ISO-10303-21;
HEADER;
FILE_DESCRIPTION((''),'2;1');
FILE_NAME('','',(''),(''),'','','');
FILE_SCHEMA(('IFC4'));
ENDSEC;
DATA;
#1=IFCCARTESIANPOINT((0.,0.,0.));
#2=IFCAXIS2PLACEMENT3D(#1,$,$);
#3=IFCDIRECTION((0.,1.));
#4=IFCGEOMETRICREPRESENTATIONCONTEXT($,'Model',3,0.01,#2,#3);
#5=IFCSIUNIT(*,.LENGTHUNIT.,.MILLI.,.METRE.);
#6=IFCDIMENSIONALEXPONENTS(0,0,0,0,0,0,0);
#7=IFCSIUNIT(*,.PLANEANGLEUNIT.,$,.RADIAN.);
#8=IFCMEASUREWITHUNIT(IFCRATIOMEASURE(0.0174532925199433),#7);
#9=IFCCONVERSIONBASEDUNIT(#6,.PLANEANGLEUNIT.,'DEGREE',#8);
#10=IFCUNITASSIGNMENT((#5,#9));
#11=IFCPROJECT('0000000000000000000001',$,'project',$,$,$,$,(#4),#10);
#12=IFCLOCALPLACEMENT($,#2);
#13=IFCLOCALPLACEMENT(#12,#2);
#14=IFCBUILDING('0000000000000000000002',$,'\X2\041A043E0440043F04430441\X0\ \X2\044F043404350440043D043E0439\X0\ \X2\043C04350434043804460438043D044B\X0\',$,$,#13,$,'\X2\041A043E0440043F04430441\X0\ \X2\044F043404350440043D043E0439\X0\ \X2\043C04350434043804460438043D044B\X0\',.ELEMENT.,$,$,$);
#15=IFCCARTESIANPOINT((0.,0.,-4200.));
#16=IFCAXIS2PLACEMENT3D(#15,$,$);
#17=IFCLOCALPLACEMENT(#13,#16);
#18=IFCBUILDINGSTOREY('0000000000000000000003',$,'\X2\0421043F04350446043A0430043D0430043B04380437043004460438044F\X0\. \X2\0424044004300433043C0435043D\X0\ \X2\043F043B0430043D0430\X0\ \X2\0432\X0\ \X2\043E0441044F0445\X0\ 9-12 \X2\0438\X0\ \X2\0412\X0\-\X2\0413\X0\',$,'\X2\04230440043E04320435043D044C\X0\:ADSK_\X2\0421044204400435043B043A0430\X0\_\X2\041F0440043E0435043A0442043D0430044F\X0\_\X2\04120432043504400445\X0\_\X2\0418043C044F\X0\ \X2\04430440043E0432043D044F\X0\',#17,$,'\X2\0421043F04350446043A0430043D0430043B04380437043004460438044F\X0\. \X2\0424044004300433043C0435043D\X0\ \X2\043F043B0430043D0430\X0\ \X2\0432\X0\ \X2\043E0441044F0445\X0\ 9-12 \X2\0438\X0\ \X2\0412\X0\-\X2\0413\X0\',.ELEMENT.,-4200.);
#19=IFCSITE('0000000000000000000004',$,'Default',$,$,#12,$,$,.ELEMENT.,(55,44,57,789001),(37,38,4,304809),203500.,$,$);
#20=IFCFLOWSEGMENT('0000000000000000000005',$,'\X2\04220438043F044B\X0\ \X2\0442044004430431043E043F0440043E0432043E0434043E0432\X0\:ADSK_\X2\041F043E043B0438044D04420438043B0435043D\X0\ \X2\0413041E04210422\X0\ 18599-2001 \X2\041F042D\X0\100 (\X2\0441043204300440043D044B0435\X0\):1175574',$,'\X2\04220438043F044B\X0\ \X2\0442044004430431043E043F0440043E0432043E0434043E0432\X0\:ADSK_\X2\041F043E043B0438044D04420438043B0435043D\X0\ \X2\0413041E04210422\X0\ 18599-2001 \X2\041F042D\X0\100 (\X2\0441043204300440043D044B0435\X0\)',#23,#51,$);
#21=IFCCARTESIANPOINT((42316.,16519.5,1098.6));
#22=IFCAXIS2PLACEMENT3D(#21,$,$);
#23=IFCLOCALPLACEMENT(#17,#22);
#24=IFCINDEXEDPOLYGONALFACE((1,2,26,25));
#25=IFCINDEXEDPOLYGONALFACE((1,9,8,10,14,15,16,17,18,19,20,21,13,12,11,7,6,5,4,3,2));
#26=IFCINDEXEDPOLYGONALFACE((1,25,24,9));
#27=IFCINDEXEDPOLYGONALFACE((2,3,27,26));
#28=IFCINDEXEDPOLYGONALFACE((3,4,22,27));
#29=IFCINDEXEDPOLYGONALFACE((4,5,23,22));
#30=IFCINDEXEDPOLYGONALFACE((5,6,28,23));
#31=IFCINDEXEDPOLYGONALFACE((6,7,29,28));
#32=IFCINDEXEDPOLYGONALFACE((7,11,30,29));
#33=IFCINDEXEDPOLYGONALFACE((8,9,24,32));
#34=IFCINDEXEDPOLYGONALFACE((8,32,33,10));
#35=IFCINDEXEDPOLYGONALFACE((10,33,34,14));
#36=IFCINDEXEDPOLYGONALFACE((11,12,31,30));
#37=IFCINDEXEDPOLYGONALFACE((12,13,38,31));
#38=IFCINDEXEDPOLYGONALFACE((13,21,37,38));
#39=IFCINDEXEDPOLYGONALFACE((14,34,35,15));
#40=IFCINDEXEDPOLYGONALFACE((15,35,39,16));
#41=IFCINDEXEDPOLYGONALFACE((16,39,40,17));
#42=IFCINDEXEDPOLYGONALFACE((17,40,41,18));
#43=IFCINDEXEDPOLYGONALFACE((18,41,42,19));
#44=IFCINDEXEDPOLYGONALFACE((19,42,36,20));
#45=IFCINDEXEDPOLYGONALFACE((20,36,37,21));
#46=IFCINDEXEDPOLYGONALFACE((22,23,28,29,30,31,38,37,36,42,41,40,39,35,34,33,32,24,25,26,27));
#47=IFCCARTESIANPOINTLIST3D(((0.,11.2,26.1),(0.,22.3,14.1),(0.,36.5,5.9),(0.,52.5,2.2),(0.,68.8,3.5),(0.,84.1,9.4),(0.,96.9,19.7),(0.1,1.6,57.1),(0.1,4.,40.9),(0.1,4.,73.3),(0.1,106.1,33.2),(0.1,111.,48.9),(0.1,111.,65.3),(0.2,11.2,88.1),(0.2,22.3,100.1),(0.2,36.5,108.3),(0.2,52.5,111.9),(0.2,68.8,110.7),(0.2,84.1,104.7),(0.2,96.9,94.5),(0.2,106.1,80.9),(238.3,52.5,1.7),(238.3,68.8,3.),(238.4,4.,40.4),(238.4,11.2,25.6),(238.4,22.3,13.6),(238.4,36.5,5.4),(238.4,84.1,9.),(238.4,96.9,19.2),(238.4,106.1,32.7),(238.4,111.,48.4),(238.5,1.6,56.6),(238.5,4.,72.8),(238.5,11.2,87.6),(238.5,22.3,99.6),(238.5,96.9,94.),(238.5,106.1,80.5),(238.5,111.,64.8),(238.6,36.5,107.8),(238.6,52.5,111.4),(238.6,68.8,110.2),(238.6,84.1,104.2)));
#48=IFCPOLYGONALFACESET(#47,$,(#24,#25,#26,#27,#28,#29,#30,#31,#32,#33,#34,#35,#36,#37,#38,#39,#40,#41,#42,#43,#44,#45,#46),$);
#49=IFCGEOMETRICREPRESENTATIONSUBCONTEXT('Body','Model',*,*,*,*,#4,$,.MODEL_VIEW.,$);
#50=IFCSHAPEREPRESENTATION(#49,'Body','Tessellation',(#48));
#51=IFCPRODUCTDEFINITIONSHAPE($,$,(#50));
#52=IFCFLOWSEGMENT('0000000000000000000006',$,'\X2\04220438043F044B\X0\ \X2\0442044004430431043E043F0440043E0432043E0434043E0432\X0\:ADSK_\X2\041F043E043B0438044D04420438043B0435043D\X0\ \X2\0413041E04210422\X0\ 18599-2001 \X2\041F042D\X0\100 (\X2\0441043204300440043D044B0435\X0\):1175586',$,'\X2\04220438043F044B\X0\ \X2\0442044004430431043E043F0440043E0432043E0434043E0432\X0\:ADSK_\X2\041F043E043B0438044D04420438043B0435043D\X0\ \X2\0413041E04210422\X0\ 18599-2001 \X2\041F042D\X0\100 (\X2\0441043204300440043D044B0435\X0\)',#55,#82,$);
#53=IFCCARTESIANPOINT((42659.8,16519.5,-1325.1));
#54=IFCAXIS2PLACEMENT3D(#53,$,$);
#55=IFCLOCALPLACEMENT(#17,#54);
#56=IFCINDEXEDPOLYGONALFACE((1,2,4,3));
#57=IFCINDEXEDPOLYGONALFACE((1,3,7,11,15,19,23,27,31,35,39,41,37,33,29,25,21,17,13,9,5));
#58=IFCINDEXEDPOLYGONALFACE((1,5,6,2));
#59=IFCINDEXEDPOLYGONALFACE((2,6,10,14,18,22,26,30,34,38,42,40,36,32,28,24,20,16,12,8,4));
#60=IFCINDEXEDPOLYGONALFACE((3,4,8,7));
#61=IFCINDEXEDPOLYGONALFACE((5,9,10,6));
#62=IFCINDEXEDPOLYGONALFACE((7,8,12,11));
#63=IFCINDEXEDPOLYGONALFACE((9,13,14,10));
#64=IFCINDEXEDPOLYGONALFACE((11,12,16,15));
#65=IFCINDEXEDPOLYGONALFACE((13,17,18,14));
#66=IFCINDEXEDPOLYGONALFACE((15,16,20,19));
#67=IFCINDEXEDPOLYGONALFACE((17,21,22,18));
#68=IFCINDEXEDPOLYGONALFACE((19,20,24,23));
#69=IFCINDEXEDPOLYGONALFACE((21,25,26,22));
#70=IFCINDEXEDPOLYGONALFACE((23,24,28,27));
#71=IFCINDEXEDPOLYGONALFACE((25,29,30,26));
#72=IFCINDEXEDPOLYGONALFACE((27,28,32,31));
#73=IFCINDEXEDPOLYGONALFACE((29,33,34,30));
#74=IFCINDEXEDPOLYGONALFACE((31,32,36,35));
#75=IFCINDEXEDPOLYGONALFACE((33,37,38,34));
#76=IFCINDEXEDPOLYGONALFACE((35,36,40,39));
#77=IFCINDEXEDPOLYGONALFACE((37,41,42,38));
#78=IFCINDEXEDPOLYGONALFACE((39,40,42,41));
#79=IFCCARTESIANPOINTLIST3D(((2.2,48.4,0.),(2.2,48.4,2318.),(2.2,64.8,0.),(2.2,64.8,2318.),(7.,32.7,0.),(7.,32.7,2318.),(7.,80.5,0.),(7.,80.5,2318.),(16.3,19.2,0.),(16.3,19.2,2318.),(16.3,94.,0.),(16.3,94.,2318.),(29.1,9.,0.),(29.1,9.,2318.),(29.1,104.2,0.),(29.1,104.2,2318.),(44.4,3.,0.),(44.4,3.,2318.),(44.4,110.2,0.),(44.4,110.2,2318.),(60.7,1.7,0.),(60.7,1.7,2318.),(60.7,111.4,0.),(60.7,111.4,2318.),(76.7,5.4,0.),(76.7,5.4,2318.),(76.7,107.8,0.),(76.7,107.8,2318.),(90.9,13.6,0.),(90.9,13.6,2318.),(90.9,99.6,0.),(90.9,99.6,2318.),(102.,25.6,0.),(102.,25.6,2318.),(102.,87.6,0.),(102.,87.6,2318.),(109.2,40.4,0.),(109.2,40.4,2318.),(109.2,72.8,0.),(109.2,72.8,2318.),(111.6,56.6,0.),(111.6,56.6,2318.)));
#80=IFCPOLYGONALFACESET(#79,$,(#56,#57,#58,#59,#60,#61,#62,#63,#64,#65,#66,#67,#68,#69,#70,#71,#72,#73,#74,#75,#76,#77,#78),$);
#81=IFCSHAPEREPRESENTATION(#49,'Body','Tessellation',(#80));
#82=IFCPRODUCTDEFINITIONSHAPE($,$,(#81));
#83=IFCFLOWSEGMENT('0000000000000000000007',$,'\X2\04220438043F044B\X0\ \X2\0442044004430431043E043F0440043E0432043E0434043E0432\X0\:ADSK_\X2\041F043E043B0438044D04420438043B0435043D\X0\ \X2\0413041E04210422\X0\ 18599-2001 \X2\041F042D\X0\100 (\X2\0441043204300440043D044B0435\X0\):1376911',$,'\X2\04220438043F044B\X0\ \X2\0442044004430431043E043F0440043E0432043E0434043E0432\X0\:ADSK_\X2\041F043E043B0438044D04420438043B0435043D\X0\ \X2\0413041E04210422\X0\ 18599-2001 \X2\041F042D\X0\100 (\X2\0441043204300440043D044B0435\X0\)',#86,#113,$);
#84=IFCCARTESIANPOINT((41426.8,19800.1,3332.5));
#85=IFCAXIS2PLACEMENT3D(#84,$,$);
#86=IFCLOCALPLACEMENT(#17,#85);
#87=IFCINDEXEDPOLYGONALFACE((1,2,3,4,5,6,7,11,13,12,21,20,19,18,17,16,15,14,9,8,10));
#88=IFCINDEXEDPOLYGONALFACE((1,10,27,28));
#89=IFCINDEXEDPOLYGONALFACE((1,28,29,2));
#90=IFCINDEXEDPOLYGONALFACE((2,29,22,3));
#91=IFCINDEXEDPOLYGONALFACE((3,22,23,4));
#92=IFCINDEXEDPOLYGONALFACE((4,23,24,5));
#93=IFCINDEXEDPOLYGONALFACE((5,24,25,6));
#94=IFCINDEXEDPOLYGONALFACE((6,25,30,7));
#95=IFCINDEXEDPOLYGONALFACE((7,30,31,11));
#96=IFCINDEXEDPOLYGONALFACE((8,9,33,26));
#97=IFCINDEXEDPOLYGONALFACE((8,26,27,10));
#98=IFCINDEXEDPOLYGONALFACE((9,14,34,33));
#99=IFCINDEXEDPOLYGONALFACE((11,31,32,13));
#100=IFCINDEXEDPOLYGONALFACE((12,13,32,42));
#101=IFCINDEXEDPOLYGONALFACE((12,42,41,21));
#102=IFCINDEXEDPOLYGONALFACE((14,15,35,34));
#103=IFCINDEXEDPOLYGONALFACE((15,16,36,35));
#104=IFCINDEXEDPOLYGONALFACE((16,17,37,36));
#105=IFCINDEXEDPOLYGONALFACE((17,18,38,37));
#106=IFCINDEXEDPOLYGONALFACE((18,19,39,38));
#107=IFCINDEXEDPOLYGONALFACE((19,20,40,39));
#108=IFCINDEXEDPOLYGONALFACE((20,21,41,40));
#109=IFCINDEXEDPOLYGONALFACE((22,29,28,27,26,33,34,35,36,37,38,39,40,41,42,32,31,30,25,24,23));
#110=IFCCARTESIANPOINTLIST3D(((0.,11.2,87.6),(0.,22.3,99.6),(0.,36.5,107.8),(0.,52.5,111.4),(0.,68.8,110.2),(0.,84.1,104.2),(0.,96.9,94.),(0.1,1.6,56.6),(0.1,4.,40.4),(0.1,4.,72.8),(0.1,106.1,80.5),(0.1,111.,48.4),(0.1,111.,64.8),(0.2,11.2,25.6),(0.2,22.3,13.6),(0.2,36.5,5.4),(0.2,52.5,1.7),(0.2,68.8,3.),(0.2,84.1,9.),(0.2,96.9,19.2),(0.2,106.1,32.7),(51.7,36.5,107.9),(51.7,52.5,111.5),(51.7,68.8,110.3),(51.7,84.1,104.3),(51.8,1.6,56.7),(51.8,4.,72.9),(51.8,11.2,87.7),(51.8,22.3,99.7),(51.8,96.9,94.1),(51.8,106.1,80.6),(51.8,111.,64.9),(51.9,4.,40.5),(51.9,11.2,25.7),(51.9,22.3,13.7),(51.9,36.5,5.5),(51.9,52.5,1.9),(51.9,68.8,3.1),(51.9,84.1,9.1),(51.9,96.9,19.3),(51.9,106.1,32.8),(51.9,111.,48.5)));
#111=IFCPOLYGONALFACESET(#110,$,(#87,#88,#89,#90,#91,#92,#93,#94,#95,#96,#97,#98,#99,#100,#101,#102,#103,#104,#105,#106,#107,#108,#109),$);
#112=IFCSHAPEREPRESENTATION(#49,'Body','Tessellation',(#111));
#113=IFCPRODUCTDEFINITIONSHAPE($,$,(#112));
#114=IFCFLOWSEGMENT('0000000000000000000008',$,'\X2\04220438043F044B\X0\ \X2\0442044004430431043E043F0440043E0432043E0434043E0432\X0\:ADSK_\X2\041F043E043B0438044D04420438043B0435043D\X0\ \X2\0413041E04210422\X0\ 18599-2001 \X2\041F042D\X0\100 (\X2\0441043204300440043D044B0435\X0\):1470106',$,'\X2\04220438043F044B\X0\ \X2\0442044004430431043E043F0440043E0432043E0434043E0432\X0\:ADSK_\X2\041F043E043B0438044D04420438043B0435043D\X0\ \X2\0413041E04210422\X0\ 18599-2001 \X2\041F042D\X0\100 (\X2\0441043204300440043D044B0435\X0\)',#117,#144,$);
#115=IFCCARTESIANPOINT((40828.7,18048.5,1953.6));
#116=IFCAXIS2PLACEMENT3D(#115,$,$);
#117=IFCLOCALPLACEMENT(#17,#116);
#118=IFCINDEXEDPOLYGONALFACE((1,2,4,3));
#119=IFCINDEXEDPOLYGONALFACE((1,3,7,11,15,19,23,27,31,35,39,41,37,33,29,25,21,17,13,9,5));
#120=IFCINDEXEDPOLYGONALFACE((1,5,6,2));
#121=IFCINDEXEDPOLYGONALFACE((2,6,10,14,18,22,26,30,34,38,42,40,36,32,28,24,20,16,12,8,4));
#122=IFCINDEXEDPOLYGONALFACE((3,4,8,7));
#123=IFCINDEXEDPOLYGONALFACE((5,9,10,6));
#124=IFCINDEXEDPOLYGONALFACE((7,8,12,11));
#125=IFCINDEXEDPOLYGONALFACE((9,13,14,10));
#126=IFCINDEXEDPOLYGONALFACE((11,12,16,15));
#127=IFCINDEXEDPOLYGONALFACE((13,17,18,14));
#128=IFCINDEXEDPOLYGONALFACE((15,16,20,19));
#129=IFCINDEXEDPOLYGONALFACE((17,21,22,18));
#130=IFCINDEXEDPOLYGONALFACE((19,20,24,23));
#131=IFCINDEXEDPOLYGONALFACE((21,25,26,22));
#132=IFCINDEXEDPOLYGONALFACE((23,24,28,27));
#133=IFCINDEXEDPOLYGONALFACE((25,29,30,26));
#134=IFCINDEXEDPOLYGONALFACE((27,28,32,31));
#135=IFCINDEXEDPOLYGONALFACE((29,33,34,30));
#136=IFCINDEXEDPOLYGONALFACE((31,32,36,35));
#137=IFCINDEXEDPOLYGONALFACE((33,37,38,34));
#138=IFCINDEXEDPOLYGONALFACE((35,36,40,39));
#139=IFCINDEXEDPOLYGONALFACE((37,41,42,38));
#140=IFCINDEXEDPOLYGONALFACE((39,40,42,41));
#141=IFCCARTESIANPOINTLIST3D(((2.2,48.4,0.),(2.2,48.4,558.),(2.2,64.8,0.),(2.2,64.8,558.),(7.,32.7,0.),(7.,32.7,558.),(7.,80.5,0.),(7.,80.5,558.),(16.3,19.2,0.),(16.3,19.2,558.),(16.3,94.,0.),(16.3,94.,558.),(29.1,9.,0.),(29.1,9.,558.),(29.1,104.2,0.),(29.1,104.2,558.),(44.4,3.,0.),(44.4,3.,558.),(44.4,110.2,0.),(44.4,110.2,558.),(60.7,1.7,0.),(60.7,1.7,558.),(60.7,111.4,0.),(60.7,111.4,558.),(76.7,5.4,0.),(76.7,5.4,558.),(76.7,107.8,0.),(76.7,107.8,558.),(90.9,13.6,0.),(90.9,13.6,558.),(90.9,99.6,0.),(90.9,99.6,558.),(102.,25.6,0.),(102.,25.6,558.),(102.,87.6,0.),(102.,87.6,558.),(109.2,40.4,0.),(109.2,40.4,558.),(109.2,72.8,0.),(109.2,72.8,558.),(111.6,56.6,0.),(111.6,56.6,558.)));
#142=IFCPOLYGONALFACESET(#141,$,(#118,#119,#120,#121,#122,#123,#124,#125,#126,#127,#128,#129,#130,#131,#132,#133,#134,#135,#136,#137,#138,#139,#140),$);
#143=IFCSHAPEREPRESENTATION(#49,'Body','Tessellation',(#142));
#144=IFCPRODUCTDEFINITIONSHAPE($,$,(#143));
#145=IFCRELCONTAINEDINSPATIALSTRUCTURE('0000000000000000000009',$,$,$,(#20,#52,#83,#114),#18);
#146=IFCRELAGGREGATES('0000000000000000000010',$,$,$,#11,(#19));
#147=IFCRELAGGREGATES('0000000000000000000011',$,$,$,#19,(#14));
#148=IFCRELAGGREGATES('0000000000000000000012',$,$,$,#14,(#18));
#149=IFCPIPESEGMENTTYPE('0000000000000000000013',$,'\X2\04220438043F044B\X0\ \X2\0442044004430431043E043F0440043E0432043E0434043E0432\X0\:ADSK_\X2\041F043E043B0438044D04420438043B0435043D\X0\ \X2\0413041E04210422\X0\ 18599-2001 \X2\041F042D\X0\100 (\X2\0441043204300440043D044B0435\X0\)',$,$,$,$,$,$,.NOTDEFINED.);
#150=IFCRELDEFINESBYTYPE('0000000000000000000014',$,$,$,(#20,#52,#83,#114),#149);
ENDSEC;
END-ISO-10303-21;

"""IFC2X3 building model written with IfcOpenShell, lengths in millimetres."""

from ifc_helpers import new_model, entity, si_unit, converted_unit, direction, frame, frame_2d, origin, origin_2d_with_axis, place, context, subcontext, project, spatial, circle, extrude, type_object, element, save


model = new_model("IFC2X3")

# Units and contexts
model_context = context("Model", 3, precision=0.01, world=origin(), true_north=direction((0.0, 1.0)))
body_context = subcontext(model_context, "Body", "Model", "MODEL_VIEW")
ifc_project = project(units=[si_unit("LENGTHUNIT", "METRE", prefix="MILLI"), converted_unit("PLANEANGLEUNIT", "DEGREE", entity("IfcRatioMeasure", 0.0174532925199433), si_unit("PLANEANGLEUNIT", "RADIAN"), dimensions=[0, 0, 0, 0, 0, 0, 0])], contexts=[model_context])

# Site, building, storey
site_placement = place(None, frame((0.0, 0.0, 0.0)))
site = spatial("IfcSite", under=ifc_project, at=site_placement, Name="Default", CompositionType="ELEMENT", RefLatitude=(55, 44, 57, 789001), RefLongitude=(37, 38, 4, 304809), RefElevation=203500.0)
building_placement = place(site_placement, origin())
building = spatial("IfcBuilding", under=site, at=building_placement, Name="Корпус ядерной медицины", LongName="Корпус ядерной медицины", CompositionType="ELEMENT")
storey_placement = place(building_placement, frame((0.0, 0.0, -4200.0)))
storey = spatial("IfcBuildingStorey", under=building, at=storey_placement, Name="Спецканализация. Фрагмен плана в осях 9-12 и В-Г", ObjectType="Уровень:ADSK_Стрелка_Проектная_Вверх_Имя уровня", LongName="Спецканализация. Фрагмен плана в осях 9-12 и В-Г", CompositionType="ELEMENT", Elevation=-4200.0)

# Flow segments
pipe_segment_type = type_object("IfcPipeSegmentType", Name="Типы трубопроводов:ADSK_Полиэтилен ГОСТ 18599-2001 ПЭ100 (сварные)", PredefinedType="NOTDEFINED")
flow_segment_1_placement = place(storey_placement, frame((42316.0, 16519.5, 1098.6)))
element("IfcFlowSegment", 1, at=flow_segment_1_placement, inside=storey, type_object=pipe_segment_type, Name="Типы трубопроводов:ADSK_Полиэтилен ГОСТ 18599-2001 ПЭ100 (сварные):1175574", ObjectType="Типы трубопроводов:ADSK_Полиэтилен ГОСТ 18599-2001 ПЭ100 (сварные)", context=body_context, shape_type="SweptSolid", body=[
    extrude(circle(Radius=55.0, at=frame_2d((0.0, 0.0), x_axis=(1.0, 0.0))), frame((0.1, 56.6, 57.1), z_axis=(0.999998, 0.0, -0.002), x_axis=(0.0, -1.0, 0.0)), (0.0, 0.0, 1.0), 238.3),
])
flow_segment_2_placement = place(storey_placement, frame((42659.8, 16519.5, -1325.1)))
element("IfcFlowSegment", 2, at=flow_segment_2_placement, inside=storey, type_object=pipe_segment_type, Name="Типы трубопроводов:ADSK_Полиэтилен ГОСТ 18599-2001 ПЭ100 (сварные):1175586", ObjectType="Типы трубопроводов:ADSK_Полиэтилен ГОСТ 18599-2001 ПЭ100 (сварные)", context=body_context, shape_type="SweptSolid", body=[
    extrude(circle(Radius=55.0, at=origin_2d_with_axis()), frame((56.6, 56.6, 0.0)), (0.0, 0.0, 1.0), 2318.0),
])
flow_segment_3_placement = place(storey_placement, frame((41426.8, 19800.1, 3332.5)))
element("IfcFlowSegment", 3, at=flow_segment_3_placement, inside=storey, type_object=pipe_segment_type, Name="Типы трубопроводов:ADSK_Полиэтилен ГОСТ 18599-2001 ПЭ100 (сварные):1376911", ObjectType="Типы трубопроводов:ADSK_Полиэтилен ГОСТ 18599-2001 ПЭ100 (сварные)", context=body_context, shape_type="SweptSolid", body=[
    extrude(circle(Radius=55.0, at=frame_2d((0.0, 0.0), x_axis=(1.0, 0.0))), frame((0.1, 56.6, 56.6), z_axis=(0.999998, 0.0, 0.002), x_axis=(0.0, -1.0, 0.0)), (0.0, 0.0, 1.0), 51.7),
])
flow_segment_4_placement = place(storey_placement, frame((40828.7, 18048.5, 1953.6)))
element("IfcFlowSegment", 4, at=flow_segment_4_placement, inside=storey, type_object=pipe_segment_type, Name="Типы трубопроводов:ADSK_Полиэтилен ГОСТ 18599-2001 ПЭ100 (сварные):1470106", ObjectType="Типы трубопроводов:ADSK_Полиэтилен ГОСТ 18599-2001 ПЭ100 (сварные)", context=body_context, shape_type="SweptSolid", body=[
    extrude(circle(Radius=55.0, at=origin_2d_with_axis()), frame((56.6, 56.6, 0.0)), (0.0, 0.0, 1.0), 558.0),
])

save(model, "model.ifc")
